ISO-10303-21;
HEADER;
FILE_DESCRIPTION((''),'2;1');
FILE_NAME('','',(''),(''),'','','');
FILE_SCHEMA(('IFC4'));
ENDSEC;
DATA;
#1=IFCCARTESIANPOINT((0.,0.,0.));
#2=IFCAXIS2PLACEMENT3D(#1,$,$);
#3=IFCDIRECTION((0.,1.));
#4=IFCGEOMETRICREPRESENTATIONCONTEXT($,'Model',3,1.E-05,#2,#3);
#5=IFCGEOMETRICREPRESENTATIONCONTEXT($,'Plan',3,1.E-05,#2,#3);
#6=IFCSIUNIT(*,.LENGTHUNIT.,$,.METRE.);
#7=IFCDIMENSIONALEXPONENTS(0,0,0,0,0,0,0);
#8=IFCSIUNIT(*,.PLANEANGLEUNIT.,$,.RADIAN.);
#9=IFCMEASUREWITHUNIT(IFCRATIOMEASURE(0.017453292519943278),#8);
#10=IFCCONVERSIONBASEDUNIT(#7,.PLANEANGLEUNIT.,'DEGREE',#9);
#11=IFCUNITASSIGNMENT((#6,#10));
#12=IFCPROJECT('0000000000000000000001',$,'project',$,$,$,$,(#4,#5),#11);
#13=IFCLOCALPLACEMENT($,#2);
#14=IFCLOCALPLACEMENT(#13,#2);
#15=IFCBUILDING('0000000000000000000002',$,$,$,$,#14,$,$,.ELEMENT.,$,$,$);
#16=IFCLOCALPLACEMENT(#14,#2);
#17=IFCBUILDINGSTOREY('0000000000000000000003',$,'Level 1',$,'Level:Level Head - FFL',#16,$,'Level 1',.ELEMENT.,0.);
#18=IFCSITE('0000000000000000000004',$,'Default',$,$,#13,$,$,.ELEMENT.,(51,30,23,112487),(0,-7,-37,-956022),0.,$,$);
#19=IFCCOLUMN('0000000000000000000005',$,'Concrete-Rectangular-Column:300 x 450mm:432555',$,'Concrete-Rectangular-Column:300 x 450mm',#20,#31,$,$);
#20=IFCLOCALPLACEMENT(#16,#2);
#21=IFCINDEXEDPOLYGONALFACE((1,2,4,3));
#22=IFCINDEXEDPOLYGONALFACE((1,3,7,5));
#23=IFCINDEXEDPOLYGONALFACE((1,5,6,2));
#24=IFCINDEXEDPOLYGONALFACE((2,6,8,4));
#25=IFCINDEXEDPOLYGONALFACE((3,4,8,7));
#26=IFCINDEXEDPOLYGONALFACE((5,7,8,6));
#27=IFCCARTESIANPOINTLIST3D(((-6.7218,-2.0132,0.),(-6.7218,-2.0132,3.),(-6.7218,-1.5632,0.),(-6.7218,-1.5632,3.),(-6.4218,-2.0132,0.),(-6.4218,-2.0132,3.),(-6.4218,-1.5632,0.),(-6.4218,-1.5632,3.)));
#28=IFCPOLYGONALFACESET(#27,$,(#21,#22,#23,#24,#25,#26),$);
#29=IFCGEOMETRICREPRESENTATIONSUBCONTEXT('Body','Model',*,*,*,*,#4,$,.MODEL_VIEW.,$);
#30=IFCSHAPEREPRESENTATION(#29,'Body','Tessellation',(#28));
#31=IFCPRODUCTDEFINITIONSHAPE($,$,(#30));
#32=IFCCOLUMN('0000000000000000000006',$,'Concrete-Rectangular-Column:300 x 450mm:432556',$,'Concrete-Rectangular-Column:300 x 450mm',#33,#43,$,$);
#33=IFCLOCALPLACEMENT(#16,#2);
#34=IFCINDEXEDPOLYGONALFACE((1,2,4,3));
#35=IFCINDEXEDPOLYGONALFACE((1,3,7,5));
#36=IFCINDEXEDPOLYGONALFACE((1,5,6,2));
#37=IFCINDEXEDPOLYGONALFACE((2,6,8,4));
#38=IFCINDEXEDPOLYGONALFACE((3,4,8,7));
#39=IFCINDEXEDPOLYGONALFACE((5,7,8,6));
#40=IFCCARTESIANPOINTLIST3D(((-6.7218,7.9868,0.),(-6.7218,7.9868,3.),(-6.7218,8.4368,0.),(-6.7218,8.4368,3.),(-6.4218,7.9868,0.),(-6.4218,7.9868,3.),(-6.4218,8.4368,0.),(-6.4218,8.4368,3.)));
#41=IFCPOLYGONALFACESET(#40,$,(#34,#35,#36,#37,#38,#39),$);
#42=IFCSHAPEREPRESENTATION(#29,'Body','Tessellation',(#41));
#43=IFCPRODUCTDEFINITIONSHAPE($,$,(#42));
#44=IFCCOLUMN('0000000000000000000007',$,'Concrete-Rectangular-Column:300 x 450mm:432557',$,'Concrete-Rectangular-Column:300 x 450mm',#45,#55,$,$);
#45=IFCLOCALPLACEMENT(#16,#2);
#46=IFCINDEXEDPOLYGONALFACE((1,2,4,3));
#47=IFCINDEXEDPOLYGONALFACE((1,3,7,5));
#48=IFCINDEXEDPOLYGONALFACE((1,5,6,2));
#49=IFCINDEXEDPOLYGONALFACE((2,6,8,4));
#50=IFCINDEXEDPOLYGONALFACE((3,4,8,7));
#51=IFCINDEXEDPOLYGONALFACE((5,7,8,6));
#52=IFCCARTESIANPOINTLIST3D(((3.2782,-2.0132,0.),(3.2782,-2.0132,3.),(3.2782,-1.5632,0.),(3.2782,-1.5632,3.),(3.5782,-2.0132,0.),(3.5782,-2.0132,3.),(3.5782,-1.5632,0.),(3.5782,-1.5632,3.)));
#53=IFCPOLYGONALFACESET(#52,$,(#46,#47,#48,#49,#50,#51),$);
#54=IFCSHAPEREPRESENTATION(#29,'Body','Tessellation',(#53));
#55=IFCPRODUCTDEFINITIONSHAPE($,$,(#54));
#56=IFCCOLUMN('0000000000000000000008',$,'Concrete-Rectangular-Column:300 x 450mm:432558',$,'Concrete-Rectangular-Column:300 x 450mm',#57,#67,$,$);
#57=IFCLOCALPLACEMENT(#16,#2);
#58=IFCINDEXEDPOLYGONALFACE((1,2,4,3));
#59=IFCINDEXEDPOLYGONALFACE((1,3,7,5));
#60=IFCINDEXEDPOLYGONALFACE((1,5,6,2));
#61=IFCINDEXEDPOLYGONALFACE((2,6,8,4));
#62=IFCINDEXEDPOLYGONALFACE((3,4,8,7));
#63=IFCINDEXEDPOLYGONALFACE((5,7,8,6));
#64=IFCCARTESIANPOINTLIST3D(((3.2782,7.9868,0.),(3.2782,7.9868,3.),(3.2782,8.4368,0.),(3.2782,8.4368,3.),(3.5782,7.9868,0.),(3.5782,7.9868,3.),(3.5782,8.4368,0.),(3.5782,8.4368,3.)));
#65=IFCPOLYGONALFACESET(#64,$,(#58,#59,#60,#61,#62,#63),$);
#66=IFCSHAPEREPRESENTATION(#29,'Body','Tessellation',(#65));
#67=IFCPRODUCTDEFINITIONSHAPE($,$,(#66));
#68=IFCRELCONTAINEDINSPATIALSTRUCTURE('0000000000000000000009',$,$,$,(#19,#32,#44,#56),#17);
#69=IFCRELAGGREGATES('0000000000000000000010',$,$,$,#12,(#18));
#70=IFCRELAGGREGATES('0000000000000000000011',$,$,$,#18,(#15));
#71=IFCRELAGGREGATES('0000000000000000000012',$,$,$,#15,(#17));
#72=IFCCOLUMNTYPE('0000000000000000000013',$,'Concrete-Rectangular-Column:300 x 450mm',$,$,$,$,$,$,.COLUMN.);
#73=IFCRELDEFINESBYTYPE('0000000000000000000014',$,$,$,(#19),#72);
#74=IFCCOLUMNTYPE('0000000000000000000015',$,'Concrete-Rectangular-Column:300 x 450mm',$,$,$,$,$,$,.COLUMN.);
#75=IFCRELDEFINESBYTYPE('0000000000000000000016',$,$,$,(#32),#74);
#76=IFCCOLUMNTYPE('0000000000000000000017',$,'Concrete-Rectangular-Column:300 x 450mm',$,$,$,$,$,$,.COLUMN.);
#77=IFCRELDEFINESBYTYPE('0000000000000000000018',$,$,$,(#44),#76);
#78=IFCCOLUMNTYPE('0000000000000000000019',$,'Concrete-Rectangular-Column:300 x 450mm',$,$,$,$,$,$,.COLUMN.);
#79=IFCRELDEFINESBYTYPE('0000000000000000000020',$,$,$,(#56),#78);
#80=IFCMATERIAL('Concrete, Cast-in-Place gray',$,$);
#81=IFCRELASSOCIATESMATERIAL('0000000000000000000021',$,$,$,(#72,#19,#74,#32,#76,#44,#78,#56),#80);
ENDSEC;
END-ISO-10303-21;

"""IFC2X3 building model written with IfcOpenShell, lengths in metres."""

from ifc_helpers import new_model, entity, si_unit, converted_unit, direction, frame, frame_2d, origin, origin_2d_with_axis, place, context, subcontext, project, spatial, rectangle, extrude, source, transform, mapped, material, type_object, type_shapes, element, save


model = new_model("IFC2X3")

# Units and contexts
model_context = context("Model", 3, precision=1e-05, world=origin(), true_north=direction((0.0, 1.0)))
plan_context = context("Plan", 3, precision=1e-05, world=origin(), true_north=direction((0.0, 1.0)))
body_context = subcontext(model_context, "Body", "Model", "MODEL_VIEW")
ifc_project = project(units=[si_unit("LENGTHUNIT", "METRE"), converted_unit("PLANEANGLEUNIT", "DEGREE", entity("IfcRatioMeasure", 0.017453292519943278), si_unit("PLANEANGLEUNIT", "RADIAN"), dimensions=[0, 0, 0, 0, 0, 0, 0])], contexts=[model_context, plan_context])

# Site, building, storey
site_placement = place(None, origin())
site = spatial("IfcSite", under=ifc_project, at=site_placement, Name="Default", CompositionType="ELEMENT", RefLatitude=(51, 30, 23, 112487), RefLongitude=(0, -7, -37, -956022), RefElevation=0.0)
building_placement = place(site_placement, origin())
building = spatial("IfcBuilding", under=site, at=building_placement, CompositionType="ELEMENT")
storey_placement = place(building_placement, origin())
storey = spatial("IfcBuildingStorey", under=building, at=storey_placement, Name="Level 1", ObjectType="Level:Level Head - FFL", LongName="Level 1", CompositionType="ELEMENT", Elevation=0.0)

# Columns
ifc_material = material(Name="Concrete, Cast-in-Place gray")
column_type_1 = type_object("IfcColumnType", Name="Concrete-Rectangular-Column:300 x 450mm", PredefinedType="COLUMN", material=ifc_material)
shared_shape_1 = source(origin(), body_context, "Body", "SweptSolid", [
    extrude(rectangle(XDim=0.45, YDim=0.3, at=frame_2d((0.0, 0.0), x_axis=(1.0, 0.0))), frame((-6.5718, -1.7882, 0.0), z_axis=(0.0, 0.0, 1.0), x_axis=(0.0, -1.0, 0.0)), (0.0, 0.0, 1.0), 3.0),
])
type_shapes(column_type_1, [shared_shape_1])
column_1_placement = place(storey_placement, origin())
element("IfcColumn", 1, at=column_1_placement, inside=storey, type_object=column_type_1, material=ifc_material, Name="Concrete-Rectangular-Column:300 x 450mm:432555", ObjectType="Concrete-Rectangular-Column:300 x 450mm", context=body_context, shape_type="MappedRepresentation", body=[
    mapped(shared_shape_1, transform((0.0, 0.0, 0.0), scale=1.0)),
])
column_type_2 = type_object("IfcColumnType", Name="Concrete-Rectangular-Column:300 x 450mm", PredefinedType="COLUMN", material=ifc_material)
shared_shape_2 = source(origin(), body_context, "Body", "SweptSolid", [
    extrude(rectangle(XDim=0.45, YDim=0.3, at=frame_2d((0.0, 0.0), x_axis=(1.0, 0.0))), frame((-6.5718, 8.2118, 0.0), z_axis=(0.0, 0.0, 1.0), x_axis=(0.0, -1.0, 0.0)), (0.0, 0.0, 1.0), 3.0),
])
type_shapes(column_type_2, [shared_shape_2])
column_2_placement = place(storey_placement, origin())
element("IfcColumn", 2, at=column_2_placement, inside=storey, type_object=column_type_2, material=ifc_material, Name="Concrete-Rectangular-Column:300 x 450mm:432556", ObjectType="Concrete-Rectangular-Column:300 x 450mm", context=body_context, shape_type="MappedRepresentation", body=[
    mapped(shared_shape_2, transform((0.0, 0.0, 0.0), scale=1.0)),
])
column_type_3 = type_object("IfcColumnType", Name="Concrete-Rectangular-Column:300 x 450mm", PredefinedType="COLUMN", material=ifc_material)
shared_shape_3 = source(origin(), body_context, "Body", "SweptSolid", [
    extrude(rectangle(XDim=0.45, YDim=0.3, at=frame_2d((0.0, 0.0), x_axis=(1.0, 0.0))), frame((3.4282, -1.7882, 0.0), z_axis=(0.0, 0.0, 1.0), x_axis=(0.0, -1.0, 0.0)), (0.0, 0.0, 1.0), 3.0),
])
type_shapes(column_type_3, [shared_shape_3])
column_3_placement = place(storey_placement, origin())
element("IfcColumn", 3, at=column_3_placement, inside=storey, type_object=column_type_3, material=ifc_material, Name="Concrete-Rectangular-Column:300 x 450mm:432557", ObjectType="Concrete-Rectangular-Column:300 x 450mm", context=body_context, shape_type="MappedRepresentation", body=[
    mapped(shared_shape_3, transform((0.0, 0.0, 0.0), scale=1.0)),
])
column_type_4 = type_object("IfcColumnType", Name="Concrete-Rectangular-Column:300 x 450mm", PredefinedType="COLUMN", material=ifc_material)
shared_shape_4 = source(origin(), body_context, "Body", "SweptSolid", [
    extrude(rectangle(XDim=0.45, YDim=0.3, at=origin_2d_with_axis()), frame((3.4282, 8.2118, 0.0), z_axis=(0.0, 0.0, 1.0), x_axis=(0.0, -1.0, 0.0)), (0.0, 0.0, 1.0), 3.0),
])
type_shapes(column_type_4, [shared_shape_4])
column_4_placement = place(storey_placement, origin())
element("IfcColumn", 4, at=column_4_placement, inside=storey, type_object=column_type_4, material=ifc_material, Name="Concrete-Rectangular-Column:300 x 450mm:432558", ObjectType="Concrete-Rectangular-Column:300 x 450mm", context=body_context, shape_type="MappedRepresentation", body=[
    mapped(shared_shape_4, transform((0.0, 0.0, 0.0), scale=1.0)),
])

save(model, "model.ifc")
